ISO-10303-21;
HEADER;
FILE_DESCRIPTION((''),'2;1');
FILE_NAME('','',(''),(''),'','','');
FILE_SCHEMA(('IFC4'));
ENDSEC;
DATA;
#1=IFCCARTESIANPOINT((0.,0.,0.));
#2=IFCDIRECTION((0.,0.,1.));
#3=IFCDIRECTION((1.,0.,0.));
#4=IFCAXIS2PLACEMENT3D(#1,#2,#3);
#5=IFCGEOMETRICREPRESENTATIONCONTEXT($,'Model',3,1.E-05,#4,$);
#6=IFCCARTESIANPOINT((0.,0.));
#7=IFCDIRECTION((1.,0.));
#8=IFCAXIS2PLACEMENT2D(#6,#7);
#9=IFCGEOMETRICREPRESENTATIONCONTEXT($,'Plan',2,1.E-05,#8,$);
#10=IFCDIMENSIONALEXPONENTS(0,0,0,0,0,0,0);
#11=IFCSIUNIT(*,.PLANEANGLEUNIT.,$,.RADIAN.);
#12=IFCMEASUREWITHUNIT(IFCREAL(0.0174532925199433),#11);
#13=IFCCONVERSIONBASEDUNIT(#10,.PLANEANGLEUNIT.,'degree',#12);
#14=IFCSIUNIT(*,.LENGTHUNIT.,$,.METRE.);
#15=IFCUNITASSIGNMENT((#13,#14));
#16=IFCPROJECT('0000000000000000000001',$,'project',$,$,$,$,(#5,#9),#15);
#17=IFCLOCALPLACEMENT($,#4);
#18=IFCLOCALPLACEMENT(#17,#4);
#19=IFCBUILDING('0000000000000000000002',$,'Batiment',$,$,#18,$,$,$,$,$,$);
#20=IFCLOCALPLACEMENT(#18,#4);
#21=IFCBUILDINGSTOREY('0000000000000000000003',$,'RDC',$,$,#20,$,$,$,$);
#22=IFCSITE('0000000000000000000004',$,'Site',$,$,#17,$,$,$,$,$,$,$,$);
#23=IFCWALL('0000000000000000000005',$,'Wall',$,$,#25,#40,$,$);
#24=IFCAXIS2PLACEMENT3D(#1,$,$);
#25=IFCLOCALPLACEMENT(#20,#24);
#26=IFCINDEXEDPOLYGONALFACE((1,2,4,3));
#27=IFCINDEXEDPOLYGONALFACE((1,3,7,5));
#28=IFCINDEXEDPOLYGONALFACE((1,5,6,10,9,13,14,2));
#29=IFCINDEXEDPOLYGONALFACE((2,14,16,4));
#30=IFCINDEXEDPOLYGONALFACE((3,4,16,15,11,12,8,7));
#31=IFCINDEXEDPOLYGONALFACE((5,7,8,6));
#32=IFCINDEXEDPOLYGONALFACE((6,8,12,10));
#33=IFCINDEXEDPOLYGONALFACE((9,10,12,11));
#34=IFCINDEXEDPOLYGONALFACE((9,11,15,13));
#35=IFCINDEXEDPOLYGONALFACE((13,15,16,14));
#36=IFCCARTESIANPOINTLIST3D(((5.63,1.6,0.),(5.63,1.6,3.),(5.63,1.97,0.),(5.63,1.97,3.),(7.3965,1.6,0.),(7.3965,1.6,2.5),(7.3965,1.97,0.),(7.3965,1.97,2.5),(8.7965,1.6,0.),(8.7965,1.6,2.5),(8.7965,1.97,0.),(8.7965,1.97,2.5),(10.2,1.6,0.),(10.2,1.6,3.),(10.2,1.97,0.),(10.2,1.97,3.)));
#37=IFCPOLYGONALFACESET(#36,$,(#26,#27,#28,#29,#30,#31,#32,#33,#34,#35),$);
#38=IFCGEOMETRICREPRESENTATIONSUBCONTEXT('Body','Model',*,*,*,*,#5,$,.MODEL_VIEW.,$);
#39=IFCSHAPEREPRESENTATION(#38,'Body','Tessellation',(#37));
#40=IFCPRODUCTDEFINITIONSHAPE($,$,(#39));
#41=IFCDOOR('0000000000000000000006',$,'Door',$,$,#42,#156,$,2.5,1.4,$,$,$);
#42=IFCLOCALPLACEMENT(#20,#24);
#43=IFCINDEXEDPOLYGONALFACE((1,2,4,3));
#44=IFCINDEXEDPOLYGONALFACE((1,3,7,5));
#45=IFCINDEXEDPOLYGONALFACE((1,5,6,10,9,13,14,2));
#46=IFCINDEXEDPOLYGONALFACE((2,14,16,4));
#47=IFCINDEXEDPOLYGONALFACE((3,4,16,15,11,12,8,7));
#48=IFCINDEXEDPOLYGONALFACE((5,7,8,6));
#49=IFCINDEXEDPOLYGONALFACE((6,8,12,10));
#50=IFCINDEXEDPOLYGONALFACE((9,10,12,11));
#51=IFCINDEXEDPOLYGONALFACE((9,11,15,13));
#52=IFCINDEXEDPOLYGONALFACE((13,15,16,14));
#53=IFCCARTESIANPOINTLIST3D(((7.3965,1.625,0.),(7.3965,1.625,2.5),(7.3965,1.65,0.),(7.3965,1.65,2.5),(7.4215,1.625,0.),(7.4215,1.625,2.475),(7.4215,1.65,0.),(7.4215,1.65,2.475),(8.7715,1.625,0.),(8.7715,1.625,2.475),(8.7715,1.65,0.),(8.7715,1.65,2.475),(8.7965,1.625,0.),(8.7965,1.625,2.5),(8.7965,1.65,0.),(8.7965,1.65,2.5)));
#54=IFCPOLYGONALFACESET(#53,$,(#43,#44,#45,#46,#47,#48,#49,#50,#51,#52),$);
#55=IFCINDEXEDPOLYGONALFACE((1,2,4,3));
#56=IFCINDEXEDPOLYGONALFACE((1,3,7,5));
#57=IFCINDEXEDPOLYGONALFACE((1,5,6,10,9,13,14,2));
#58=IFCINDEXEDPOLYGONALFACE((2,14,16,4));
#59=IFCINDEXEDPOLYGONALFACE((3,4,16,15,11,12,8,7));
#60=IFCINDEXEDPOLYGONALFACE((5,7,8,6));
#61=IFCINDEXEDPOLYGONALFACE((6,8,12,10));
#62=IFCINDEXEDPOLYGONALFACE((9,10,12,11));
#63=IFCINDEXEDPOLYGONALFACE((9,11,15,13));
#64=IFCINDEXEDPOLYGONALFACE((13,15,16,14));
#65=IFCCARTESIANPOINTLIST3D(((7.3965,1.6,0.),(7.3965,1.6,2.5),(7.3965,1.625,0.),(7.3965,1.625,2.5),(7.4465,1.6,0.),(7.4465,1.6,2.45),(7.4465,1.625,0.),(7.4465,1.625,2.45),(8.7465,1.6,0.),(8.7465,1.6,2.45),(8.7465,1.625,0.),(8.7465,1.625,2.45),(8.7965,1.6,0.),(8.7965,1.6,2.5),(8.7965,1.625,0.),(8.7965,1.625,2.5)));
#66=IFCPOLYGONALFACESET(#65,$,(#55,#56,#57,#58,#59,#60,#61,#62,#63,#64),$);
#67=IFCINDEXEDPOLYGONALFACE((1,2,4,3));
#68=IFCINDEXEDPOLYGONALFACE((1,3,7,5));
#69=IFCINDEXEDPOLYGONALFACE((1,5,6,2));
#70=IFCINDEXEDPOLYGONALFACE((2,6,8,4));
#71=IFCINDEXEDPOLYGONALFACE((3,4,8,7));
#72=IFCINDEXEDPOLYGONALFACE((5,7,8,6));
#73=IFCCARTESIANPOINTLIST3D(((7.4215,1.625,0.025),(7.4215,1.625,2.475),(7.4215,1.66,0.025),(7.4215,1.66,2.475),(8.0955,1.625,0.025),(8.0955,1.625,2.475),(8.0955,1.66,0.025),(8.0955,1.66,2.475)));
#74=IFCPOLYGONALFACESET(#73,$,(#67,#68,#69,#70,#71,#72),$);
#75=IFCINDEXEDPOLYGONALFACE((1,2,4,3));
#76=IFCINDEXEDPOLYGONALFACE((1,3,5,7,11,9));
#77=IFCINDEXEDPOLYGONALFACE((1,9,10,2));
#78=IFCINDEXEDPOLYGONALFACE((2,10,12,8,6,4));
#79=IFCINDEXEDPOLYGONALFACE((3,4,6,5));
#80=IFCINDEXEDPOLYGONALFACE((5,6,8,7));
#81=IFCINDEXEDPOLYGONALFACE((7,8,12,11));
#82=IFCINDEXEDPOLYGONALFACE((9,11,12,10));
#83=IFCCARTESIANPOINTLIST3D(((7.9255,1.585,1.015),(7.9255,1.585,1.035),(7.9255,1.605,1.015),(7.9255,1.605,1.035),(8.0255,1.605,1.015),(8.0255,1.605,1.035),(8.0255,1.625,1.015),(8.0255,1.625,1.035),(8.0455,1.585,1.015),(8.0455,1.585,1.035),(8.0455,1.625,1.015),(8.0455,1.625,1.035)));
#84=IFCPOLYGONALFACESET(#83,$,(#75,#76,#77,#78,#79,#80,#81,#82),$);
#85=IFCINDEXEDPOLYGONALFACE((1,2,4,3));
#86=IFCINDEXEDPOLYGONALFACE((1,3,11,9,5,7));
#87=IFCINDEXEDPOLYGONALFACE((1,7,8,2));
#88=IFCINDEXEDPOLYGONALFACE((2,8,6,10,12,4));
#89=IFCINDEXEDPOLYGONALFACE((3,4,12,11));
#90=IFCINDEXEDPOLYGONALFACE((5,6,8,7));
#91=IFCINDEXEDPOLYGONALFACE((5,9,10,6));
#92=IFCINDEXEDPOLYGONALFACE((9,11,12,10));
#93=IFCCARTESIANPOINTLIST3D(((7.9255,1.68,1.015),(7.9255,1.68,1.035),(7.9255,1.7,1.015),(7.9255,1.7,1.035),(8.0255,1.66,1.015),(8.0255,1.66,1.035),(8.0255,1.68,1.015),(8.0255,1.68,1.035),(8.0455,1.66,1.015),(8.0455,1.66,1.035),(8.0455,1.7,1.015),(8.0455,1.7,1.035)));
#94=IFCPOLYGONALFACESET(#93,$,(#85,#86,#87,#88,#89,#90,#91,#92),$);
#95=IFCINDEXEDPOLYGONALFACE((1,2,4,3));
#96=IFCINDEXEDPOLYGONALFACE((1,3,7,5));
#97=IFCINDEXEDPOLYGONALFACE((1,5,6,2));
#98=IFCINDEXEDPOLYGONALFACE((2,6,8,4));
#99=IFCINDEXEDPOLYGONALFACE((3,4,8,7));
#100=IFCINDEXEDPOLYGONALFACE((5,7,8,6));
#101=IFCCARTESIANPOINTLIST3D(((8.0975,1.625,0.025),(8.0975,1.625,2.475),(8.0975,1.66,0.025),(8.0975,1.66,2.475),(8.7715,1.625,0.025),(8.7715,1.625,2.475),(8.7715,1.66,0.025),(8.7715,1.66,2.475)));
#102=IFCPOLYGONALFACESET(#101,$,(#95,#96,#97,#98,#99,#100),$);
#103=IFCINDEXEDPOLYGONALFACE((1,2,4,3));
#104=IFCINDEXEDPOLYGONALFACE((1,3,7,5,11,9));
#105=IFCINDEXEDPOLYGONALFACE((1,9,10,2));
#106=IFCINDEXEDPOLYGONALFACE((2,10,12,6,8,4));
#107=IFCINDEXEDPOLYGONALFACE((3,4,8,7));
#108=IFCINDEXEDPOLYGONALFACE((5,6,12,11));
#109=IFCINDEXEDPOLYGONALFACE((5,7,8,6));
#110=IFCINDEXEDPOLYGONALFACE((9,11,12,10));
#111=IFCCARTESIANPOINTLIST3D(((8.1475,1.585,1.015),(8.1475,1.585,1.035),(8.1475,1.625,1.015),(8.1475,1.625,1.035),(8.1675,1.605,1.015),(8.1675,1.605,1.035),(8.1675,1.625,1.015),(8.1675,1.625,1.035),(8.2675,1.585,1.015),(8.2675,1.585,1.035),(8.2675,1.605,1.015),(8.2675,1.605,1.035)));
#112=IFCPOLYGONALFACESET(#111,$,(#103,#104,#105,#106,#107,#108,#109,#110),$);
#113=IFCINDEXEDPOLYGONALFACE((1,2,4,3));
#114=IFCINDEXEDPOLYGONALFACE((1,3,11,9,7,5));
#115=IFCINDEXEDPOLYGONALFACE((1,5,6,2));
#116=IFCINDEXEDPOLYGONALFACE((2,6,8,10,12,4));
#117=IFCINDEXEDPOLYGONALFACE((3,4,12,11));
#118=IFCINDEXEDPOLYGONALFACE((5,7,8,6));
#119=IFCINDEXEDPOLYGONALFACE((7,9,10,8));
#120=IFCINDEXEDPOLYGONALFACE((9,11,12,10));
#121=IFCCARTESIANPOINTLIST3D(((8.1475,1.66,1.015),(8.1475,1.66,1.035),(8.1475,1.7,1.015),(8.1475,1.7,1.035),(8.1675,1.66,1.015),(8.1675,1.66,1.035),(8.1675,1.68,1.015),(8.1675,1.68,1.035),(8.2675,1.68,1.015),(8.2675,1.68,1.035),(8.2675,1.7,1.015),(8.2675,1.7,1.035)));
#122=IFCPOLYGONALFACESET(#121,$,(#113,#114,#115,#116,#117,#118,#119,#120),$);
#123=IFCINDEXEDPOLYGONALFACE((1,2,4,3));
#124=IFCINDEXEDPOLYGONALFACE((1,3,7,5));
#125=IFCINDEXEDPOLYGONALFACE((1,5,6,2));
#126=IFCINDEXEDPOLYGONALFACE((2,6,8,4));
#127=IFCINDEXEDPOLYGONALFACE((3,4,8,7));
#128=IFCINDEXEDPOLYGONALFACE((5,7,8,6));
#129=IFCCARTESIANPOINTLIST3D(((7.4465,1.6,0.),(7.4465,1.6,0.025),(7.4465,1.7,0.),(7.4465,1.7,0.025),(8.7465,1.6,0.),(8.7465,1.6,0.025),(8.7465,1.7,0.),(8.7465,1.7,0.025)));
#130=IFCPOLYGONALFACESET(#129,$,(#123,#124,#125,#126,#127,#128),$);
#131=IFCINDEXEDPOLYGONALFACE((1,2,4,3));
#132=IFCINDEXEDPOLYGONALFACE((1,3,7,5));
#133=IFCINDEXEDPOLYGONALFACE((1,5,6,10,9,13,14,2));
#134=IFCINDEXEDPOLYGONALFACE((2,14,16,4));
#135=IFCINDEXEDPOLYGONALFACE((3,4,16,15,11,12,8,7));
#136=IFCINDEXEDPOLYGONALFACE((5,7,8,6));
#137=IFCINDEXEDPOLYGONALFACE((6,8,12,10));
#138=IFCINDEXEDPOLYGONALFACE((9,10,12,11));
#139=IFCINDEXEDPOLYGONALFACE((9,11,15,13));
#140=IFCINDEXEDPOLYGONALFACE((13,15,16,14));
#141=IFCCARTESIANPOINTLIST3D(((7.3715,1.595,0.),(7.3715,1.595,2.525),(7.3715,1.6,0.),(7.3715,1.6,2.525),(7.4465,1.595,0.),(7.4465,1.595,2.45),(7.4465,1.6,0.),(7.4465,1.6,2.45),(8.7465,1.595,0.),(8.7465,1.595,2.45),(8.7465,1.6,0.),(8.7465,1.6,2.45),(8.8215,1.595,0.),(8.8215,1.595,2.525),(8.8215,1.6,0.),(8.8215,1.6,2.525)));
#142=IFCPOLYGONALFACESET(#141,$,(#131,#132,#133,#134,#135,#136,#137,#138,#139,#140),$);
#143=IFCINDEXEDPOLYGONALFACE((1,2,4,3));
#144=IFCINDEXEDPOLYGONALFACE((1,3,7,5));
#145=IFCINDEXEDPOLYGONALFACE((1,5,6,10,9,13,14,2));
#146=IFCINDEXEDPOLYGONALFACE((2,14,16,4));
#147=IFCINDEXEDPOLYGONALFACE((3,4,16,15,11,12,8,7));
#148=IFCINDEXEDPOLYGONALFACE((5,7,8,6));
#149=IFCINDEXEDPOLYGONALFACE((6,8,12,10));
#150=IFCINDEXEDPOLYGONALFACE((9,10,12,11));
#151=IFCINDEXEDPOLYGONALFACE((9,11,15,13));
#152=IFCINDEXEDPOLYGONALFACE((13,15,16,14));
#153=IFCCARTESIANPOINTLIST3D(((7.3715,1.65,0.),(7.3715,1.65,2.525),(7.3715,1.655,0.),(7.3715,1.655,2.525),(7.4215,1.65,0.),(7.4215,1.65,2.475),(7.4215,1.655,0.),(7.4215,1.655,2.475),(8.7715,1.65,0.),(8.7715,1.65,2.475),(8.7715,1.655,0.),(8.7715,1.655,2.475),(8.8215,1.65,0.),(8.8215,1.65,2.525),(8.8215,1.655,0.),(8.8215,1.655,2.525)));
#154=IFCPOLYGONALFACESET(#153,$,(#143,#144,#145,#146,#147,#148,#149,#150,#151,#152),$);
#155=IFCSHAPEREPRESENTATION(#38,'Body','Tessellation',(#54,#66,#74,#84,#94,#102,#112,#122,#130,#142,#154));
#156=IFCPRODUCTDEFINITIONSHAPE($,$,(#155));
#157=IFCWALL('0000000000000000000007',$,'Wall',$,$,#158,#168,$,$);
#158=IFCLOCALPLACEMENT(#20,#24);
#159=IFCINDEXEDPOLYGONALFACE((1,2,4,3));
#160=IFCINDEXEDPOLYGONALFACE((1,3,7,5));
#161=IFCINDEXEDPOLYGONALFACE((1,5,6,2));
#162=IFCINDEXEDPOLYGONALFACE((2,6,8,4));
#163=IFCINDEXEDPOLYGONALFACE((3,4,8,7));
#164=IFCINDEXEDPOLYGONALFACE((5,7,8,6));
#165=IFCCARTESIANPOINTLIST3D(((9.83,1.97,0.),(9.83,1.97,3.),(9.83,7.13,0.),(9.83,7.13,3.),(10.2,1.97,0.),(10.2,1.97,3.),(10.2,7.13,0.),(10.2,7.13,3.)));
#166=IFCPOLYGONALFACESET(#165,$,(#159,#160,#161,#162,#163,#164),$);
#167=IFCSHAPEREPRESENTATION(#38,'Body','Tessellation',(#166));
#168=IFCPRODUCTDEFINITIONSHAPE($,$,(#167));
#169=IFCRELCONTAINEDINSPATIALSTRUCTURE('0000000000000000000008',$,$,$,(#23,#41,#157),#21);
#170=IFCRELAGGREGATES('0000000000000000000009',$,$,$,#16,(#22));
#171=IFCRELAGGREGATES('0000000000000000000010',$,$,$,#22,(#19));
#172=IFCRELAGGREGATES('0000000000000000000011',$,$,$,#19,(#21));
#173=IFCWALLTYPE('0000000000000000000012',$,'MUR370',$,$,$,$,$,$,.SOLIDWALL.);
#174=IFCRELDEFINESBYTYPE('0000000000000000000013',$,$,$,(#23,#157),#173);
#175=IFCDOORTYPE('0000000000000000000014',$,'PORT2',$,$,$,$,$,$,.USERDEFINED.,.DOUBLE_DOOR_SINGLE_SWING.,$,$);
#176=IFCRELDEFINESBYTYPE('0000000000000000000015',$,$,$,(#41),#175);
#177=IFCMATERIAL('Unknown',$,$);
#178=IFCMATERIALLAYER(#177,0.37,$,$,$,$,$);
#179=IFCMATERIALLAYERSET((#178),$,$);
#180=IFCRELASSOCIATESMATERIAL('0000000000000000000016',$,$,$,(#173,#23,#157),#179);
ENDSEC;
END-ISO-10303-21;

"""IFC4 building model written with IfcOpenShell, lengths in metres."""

from ifc_helpers import new_model, entity, si_unit, converted_unit, frame, origin_with_axes, origin_2d_with_axis, place, context, subcontext, project, spatial, line, indexed_curve, outline, extrude, shape, source, transform, mapped, material, layer, layer_set, layer_usage, type_object, type_shapes, element, fill, save


model = new_model("IFC4")

# Units and contexts
model_context = context("Model", 3, precision=1e-05, world=origin_with_axes())
plan_context = context("Plan", 2, precision=1e-05, world=origin_2d_with_axis())
body_context_1 = subcontext(model_context, "Body", "Model", "MODEL_VIEW")
body_context_2 = subcontext(plan_context, "Body", "Plan", "PLAN_VIEW")
ifc_project = project(units=[converted_unit("PLANEANGLEUNIT", "degree", entity("IfcReal", 0.0174532925199433), si_unit("PLANEANGLEUNIT", "RADIAN"), dimensions=[0, 0, 0, 0, 0, 0, 0]), si_unit("LENGTHUNIT", "METRE")], contexts=[model_context, plan_context])

# Site, building, storey
site_placement = place(None, origin_with_axes())
site = spatial("IfcSite", under=ifc_project, at=site_placement, Name="Site")
building_placement = place(site_placement, origin_with_axes())
building = spatial("IfcBuilding", under=site, at=building_placement, Name="Batiment")
storey_placement = place(building_placement, origin_with_axes())
storey = spatial("IfcBuildingStorey", under=building, at=storey_placement, Name="RDC")

# Shared definitions
ifc_material = material(Name="Unknown")

# Shared definitions
ifc_layer_1 = layer(ifc_material, 0.37)
ifc_layer_set_1 = layer_set([ifc_layer_1])
wall_type_1 = type_object("IfcWallType", Name="MUR370", PredefinedType="SOLIDWALL", material=ifc_layer_set_1)

# Wall, opening, door
ifc_layer_usage_1 = layer_usage(ifc_layer_set_1, "AXIS2", "POSITIVE", 0.0)
wall_1_placement = place(storey_placement, frame((5.63, 1.6, 0.0), z_axis=(0.0, 0.0, 1.0), x_axis=(1.0, -0.000001, 0.0)))
wall_1 = element("IfcWall", 1, at=wall_1_placement, inside=storey, type_object=wall_type_1, material=ifc_layer_usage_1, Name="Wall", context=body_context_1, shape_type="SweptSolid", body=[
    extrude(outline(indexed_curve([(0.0, 0.0), (0.0, 0.37), (4.57, 0.37), (4.57, 0.0), (0.0, 0.0)], self_intersect=False)), origin_with_axes(), (0.0, 0.0, 1.0), 3.0),
])
shared_shape_1 = source(origin_with_axes(), body_context_1, "Body", "SweptSolid", [
    extrude(outline(indexed_curve([(0.0, 0.0), (1.4, 0.0), (1.4, 2.5), (0.0, 2.5)], segments=[line(1, 2, 3, 4, 1)])), frame((0.0, -0.1, 0.0), z_axis=(0.0, -1.0, 0.0), x_axis=(1.0, 0.0, 0.0)), (0.0, 0.0, -1.0), 0.57),
])
opening_1_placement = place(wall_1_placement, frame((1.7665, 0.0, 0.0), z_axis=(0.0, 0.0, 1.0), x_axis=(1.0, 0.0, 0.0)))
opening_1 = element("IfcOpeningElement", 2, at=opening_1_placement, cuts=wall_1, PredefinedType="OPENING", context=body_context_1, shape_type="MappedRepresentation", body=[
    mapped(shared_shape_1, transform((0.0, 0.0, 0.0), x_axis=(1.0, 0.0, 0.0), y_axis=(0.0, 1.0, 0.0), z_axis=(0.0, 0.0, 1.0), scale=1.0)),
])
door_type_1 = type_object("IfcDoorType", Name="PORT2", OperationType="DOUBLE_DOOR_SINGLE_SWING", PredefinedType="USERDEFINED")
shared_shape_2 = source(origin_with_axes(), body_context_1, "Body", "SweptSolid", [
    extrude(outline(indexed_curve([(0.0, 0.0), (0.0, 2.5), (1.4, 2.5), (1.4, 0.0), (1.375, 0.0), (1.375, 2.475), (0.025, 2.475), (0.025, 0.0)], segments=[line(1, 2, 3, 4, 5, 6, 7, 8, 1)])), frame((0.0, 0.025, 0.0), z_axis=(0.0, -1.0, 0.0), x_axis=(1.0, 0.0, 0.0)), (0.0, 0.0, -1.0), 0.025),
    extrude(outline(indexed_curve([(0.0, 0.0), (0.0, 2.5), (1.4, 2.5), (1.4, 0.0), (1.35, 0.0), (1.35, 2.45), (0.05, 2.45), (0.05, 0.0)], segments=[line(1, 2, 3, 4, 5, 6, 7, 8, 1)])), frame((0.0, 0.0, 0.0), z_axis=(0.0, -1.0, 0.0), x_axis=(1.0, 0.0, 0.0)), (0.0, 0.0, -1.0), 0.025),
    extrude(outline(indexed_curve([(0.0, 0.0), (0.674, 0.0), (0.674, 0.035), (0.0, 0.035)], segments=[line(1, 2, 3, 4, 1)])), frame((0.025, 0.025, 0.025), z_axis=(0.0, 0.0, 1.0), x_axis=(1.0, 0.0, 0.0)), (0.0, 0.0, 1.0), 2.45),
    extrude(outline(indexed_curve([(0.0, 0.0), (0.0, -0.04), (-0.12, -0.04), (-0.12, -0.02), (-0.02, -0.02), (-0.02, 0.0)], segments=[line(1, 2, 3, 4, 5, 6, 1)])), frame((0.649, 0.025, 1.015), z_axis=(0.0, 0.0, 1.0), x_axis=(1.0, 0.0, 0.0)), (0.0, 0.0, 1.0), 0.02),
    extrude(outline(indexed_curve([(0.0, 0.0), (0.0, 0.04), (-0.12, 0.04), (-0.12, 0.02), (-0.02, 0.02), (-0.02, 0.0)], segments=[line(1, 2, 3, 4, 5, 6, 1)])), frame((0.649, 0.06, 1.015), z_axis=(0.0, 0.0, 1.0), x_axis=(1.0, 0.0, 0.0)), (0.0, 0.0, 1.0), 0.02),
    extrude(outline(indexed_curve([(0.0, 0.0), (-0.674, 0.0), (-0.674, 0.035), (0.0, 0.035)], segments=[line(1, 2, 3, 4, 1)])), frame((1.375, 0.025, 0.025), z_axis=(0.0, 0.0, 1.0), x_axis=(1.0, 0.0, 0.0)), (0.0, 0.0, 1.0), 2.45),
    extrude(outline(indexed_curve([(0.0, 0.0), (0.0, -0.04), (0.12, -0.04), (0.12, -0.02), (0.02, -0.02), (0.02, 0.0)], segments=[line(1, 2, 3, 4, 5, 6, 1)])), frame((0.751, 0.025, 1.015), z_axis=(0.0, 0.0, 1.0), x_axis=(1.0, 0.0, 0.0)), (0.0, 0.0, 1.0), 0.02),
    extrude(outline(indexed_curve([(0.0, 0.0), (0.0, 0.04), (0.12, 0.04), (0.12, 0.02), (0.02, 0.02), (0.02, 0.0)], segments=[line(1, 2, 3, 4, 5, 6, 1)])), frame((0.751, 0.06, 1.015), z_axis=(0.0, 0.0, 1.0), x_axis=(1.0, 0.0, 0.0)), (0.0, 0.0, 1.0), 0.02),
    extrude(outline(indexed_curve([(0.0, 0.0), (1.3, 0.0), (1.3, 0.1), (0.0, 0.1)], segments=[line(1, 2, 3, 4, 1)])), frame((0.05, 0.0, 0.0), z_axis=(0.0, 0.0, 1.0), x_axis=(1.0, 0.0, 0.0)), (0.0, 0.0, 1.0), 0.025),
    extrude(outline(indexed_curve([(0.0, 0.0), (0.0, 2.525), (1.45, 2.525), (1.45, 0.0), (1.375, 0.0), (1.375, 2.45), (0.075, 2.45), (0.075, 0.0)], segments=[line(1, 2, 3, 4, 5, 6, 7, 8, 1)])), frame((-0.025, -0.005, 0.0), z_axis=(0.0, -1.0, 0.0), x_axis=(1.0, 0.0, 0.0)), (0.0, 0.0, -1.0), 0.005),
    extrude(outline(indexed_curve([(0.0, 0.0), (0.0, 2.525), (1.45, 2.525), (1.45, 0.0), (1.4, 0.0), (1.4, 2.475), (0.05, 2.475), (0.05, 0.0)], segments=[line(1, 2, 3, 4, 5, 6, 7, 8, 1)])), frame((-0.025, 0.05, 0.0), z_axis=(0.0, -1.0, 0.0), x_axis=(1.0, 0.0, 0.0)), (0.0, 0.0, -1.0), 0.005),
])
shared_shape_3 = source(origin_with_axes(), body_context_2, "Body", "Curve2D", [
    entity("IfcIndexedPolyCurve", entity("IfcCartesianPointList2D", [[0.0, 0.0], [0.0, 0.05], [0.025, 0.05], [0.025, 0.025], [0.05, 0.025], [0.05, 0.0]]), [entity("IfcLineIndex", [1, 2, 3, 4, 5, 6, 1])]),
    entity("IfcIndexedPolyCurve", entity("IfcCartesianPointList2D", [[1.4, 0.0], [1.4, 0.05], [1.375, 0.05], [1.375, 0.025], [1.35, 0.025], [1.35, 0.0]]), [entity("IfcLineIndex", [1, 2, 3, 4, 5, 6, 1])]),
    entity("IfcTrimmedCurve", entity("IfcEllipse", entity("IfcAxis2Placement2D", entity("IfcCartesianPoint", [0.06, 0.05]), entity("IfcDirection", [1.0, 0.0])), 0.64, 0.675), [entity("IfcCartesianPoint", [0.7, 0.05])], [entity("IfcCartesianPoint", [0.06, 0.725])], True, "CARTESIAN"),
    entity("IfcIndexedPolyCurve", entity("IfcCartesianPointList2D", [[0.025, 0.05], [0.06, 0.05], [0.06, 0.725], [0.025, 0.725]]), [entity("IfcLineIndex", [1, 2, 3, 4, 1])]),
    entity("IfcTrimmedCurve", entity("IfcEllipse", entity("IfcAxis2Placement2D", entity("IfcCartesianPoint", [1.34, 0.05]), entity("IfcDirection", [1.0, 0.0])), 0.64, 0.675), [entity("IfcCartesianPoint", [1.34, 0.725])], [entity("IfcCartesianPoint", [0.7, 0.05])], True, "CARTESIAN"),
    entity("IfcIndexedPolyCurve", entity("IfcCartesianPointList2D", [[1.375, 0.05], [1.34, 0.05], [1.34, 0.725], [1.375, 0.725]]), [entity("IfcLineIndex", [1, 2, 3, 4, 1])]),
])
type_shapes(door_type_1, [shared_shape_2, shared_shape_3])
door_1_placement = place(opening_1_placement, frame((0.0, 0.0, 0.0), z_axis=(0.0, 0.0, 1.0), x_axis=(1.0, 0.0, 0.0)))
door_1 = element("IfcDoor", 3, at=door_1_placement, inside=storey, type_object=door_type_1, Name="Door", OverallHeight=2.5, OverallWidth=1.4, shapes=[
    shape(body_context_1, "Body", "MappedRepresentation", [mapped(shared_shape_2, transform((0.0, 0.0, 0.0), x_axis=(1.0, 0.0, 0.0), y_axis=(0.0, 1.0, 0.0), z_axis=(0.0, 0.0, 1.0), scale=1.0))]),
    shape(body_context_2, "Body", "MappedRepresentation", [mapped(shared_shape_3, transform((0.0, 0.0, 0.0), x_axis=(1.0, 0.0, 0.0), y_axis=(0.0, 1.0, 0.0), z_axis=(0.0, 0.0, 1.0), scale=1.0))]),
])
fill(opening_1, door_1)

# Wall
ifc_layer_usage_2 = layer_usage(ifc_layer_set_1, "AXIS2", "POSITIVE", 0.0)
wall_2_placement = place(storey_placement, frame((10.2, 1.97, 0.0), z_axis=(0.0, 0.0, 1.0), x_axis=(0.000001, 1.0, 0.0)))
element("IfcWall", 4, at=wall_2_placement, inside=storey, type_object=wall_type_1, material=ifc_layer_usage_2, Name="Wall", context=body_context_1, shape_type="SweptSolid", body=[
    extrude(outline(indexed_curve([(0.0, 0.0), (0.0, 0.37), (5.16, 0.37), (5.16, 0.0), (0.0, 0.0)], self_intersect=False)), origin_with_axes(), (0.0, 0.0, 1.0), 3.0),
])

save(model, "model.ifc")
